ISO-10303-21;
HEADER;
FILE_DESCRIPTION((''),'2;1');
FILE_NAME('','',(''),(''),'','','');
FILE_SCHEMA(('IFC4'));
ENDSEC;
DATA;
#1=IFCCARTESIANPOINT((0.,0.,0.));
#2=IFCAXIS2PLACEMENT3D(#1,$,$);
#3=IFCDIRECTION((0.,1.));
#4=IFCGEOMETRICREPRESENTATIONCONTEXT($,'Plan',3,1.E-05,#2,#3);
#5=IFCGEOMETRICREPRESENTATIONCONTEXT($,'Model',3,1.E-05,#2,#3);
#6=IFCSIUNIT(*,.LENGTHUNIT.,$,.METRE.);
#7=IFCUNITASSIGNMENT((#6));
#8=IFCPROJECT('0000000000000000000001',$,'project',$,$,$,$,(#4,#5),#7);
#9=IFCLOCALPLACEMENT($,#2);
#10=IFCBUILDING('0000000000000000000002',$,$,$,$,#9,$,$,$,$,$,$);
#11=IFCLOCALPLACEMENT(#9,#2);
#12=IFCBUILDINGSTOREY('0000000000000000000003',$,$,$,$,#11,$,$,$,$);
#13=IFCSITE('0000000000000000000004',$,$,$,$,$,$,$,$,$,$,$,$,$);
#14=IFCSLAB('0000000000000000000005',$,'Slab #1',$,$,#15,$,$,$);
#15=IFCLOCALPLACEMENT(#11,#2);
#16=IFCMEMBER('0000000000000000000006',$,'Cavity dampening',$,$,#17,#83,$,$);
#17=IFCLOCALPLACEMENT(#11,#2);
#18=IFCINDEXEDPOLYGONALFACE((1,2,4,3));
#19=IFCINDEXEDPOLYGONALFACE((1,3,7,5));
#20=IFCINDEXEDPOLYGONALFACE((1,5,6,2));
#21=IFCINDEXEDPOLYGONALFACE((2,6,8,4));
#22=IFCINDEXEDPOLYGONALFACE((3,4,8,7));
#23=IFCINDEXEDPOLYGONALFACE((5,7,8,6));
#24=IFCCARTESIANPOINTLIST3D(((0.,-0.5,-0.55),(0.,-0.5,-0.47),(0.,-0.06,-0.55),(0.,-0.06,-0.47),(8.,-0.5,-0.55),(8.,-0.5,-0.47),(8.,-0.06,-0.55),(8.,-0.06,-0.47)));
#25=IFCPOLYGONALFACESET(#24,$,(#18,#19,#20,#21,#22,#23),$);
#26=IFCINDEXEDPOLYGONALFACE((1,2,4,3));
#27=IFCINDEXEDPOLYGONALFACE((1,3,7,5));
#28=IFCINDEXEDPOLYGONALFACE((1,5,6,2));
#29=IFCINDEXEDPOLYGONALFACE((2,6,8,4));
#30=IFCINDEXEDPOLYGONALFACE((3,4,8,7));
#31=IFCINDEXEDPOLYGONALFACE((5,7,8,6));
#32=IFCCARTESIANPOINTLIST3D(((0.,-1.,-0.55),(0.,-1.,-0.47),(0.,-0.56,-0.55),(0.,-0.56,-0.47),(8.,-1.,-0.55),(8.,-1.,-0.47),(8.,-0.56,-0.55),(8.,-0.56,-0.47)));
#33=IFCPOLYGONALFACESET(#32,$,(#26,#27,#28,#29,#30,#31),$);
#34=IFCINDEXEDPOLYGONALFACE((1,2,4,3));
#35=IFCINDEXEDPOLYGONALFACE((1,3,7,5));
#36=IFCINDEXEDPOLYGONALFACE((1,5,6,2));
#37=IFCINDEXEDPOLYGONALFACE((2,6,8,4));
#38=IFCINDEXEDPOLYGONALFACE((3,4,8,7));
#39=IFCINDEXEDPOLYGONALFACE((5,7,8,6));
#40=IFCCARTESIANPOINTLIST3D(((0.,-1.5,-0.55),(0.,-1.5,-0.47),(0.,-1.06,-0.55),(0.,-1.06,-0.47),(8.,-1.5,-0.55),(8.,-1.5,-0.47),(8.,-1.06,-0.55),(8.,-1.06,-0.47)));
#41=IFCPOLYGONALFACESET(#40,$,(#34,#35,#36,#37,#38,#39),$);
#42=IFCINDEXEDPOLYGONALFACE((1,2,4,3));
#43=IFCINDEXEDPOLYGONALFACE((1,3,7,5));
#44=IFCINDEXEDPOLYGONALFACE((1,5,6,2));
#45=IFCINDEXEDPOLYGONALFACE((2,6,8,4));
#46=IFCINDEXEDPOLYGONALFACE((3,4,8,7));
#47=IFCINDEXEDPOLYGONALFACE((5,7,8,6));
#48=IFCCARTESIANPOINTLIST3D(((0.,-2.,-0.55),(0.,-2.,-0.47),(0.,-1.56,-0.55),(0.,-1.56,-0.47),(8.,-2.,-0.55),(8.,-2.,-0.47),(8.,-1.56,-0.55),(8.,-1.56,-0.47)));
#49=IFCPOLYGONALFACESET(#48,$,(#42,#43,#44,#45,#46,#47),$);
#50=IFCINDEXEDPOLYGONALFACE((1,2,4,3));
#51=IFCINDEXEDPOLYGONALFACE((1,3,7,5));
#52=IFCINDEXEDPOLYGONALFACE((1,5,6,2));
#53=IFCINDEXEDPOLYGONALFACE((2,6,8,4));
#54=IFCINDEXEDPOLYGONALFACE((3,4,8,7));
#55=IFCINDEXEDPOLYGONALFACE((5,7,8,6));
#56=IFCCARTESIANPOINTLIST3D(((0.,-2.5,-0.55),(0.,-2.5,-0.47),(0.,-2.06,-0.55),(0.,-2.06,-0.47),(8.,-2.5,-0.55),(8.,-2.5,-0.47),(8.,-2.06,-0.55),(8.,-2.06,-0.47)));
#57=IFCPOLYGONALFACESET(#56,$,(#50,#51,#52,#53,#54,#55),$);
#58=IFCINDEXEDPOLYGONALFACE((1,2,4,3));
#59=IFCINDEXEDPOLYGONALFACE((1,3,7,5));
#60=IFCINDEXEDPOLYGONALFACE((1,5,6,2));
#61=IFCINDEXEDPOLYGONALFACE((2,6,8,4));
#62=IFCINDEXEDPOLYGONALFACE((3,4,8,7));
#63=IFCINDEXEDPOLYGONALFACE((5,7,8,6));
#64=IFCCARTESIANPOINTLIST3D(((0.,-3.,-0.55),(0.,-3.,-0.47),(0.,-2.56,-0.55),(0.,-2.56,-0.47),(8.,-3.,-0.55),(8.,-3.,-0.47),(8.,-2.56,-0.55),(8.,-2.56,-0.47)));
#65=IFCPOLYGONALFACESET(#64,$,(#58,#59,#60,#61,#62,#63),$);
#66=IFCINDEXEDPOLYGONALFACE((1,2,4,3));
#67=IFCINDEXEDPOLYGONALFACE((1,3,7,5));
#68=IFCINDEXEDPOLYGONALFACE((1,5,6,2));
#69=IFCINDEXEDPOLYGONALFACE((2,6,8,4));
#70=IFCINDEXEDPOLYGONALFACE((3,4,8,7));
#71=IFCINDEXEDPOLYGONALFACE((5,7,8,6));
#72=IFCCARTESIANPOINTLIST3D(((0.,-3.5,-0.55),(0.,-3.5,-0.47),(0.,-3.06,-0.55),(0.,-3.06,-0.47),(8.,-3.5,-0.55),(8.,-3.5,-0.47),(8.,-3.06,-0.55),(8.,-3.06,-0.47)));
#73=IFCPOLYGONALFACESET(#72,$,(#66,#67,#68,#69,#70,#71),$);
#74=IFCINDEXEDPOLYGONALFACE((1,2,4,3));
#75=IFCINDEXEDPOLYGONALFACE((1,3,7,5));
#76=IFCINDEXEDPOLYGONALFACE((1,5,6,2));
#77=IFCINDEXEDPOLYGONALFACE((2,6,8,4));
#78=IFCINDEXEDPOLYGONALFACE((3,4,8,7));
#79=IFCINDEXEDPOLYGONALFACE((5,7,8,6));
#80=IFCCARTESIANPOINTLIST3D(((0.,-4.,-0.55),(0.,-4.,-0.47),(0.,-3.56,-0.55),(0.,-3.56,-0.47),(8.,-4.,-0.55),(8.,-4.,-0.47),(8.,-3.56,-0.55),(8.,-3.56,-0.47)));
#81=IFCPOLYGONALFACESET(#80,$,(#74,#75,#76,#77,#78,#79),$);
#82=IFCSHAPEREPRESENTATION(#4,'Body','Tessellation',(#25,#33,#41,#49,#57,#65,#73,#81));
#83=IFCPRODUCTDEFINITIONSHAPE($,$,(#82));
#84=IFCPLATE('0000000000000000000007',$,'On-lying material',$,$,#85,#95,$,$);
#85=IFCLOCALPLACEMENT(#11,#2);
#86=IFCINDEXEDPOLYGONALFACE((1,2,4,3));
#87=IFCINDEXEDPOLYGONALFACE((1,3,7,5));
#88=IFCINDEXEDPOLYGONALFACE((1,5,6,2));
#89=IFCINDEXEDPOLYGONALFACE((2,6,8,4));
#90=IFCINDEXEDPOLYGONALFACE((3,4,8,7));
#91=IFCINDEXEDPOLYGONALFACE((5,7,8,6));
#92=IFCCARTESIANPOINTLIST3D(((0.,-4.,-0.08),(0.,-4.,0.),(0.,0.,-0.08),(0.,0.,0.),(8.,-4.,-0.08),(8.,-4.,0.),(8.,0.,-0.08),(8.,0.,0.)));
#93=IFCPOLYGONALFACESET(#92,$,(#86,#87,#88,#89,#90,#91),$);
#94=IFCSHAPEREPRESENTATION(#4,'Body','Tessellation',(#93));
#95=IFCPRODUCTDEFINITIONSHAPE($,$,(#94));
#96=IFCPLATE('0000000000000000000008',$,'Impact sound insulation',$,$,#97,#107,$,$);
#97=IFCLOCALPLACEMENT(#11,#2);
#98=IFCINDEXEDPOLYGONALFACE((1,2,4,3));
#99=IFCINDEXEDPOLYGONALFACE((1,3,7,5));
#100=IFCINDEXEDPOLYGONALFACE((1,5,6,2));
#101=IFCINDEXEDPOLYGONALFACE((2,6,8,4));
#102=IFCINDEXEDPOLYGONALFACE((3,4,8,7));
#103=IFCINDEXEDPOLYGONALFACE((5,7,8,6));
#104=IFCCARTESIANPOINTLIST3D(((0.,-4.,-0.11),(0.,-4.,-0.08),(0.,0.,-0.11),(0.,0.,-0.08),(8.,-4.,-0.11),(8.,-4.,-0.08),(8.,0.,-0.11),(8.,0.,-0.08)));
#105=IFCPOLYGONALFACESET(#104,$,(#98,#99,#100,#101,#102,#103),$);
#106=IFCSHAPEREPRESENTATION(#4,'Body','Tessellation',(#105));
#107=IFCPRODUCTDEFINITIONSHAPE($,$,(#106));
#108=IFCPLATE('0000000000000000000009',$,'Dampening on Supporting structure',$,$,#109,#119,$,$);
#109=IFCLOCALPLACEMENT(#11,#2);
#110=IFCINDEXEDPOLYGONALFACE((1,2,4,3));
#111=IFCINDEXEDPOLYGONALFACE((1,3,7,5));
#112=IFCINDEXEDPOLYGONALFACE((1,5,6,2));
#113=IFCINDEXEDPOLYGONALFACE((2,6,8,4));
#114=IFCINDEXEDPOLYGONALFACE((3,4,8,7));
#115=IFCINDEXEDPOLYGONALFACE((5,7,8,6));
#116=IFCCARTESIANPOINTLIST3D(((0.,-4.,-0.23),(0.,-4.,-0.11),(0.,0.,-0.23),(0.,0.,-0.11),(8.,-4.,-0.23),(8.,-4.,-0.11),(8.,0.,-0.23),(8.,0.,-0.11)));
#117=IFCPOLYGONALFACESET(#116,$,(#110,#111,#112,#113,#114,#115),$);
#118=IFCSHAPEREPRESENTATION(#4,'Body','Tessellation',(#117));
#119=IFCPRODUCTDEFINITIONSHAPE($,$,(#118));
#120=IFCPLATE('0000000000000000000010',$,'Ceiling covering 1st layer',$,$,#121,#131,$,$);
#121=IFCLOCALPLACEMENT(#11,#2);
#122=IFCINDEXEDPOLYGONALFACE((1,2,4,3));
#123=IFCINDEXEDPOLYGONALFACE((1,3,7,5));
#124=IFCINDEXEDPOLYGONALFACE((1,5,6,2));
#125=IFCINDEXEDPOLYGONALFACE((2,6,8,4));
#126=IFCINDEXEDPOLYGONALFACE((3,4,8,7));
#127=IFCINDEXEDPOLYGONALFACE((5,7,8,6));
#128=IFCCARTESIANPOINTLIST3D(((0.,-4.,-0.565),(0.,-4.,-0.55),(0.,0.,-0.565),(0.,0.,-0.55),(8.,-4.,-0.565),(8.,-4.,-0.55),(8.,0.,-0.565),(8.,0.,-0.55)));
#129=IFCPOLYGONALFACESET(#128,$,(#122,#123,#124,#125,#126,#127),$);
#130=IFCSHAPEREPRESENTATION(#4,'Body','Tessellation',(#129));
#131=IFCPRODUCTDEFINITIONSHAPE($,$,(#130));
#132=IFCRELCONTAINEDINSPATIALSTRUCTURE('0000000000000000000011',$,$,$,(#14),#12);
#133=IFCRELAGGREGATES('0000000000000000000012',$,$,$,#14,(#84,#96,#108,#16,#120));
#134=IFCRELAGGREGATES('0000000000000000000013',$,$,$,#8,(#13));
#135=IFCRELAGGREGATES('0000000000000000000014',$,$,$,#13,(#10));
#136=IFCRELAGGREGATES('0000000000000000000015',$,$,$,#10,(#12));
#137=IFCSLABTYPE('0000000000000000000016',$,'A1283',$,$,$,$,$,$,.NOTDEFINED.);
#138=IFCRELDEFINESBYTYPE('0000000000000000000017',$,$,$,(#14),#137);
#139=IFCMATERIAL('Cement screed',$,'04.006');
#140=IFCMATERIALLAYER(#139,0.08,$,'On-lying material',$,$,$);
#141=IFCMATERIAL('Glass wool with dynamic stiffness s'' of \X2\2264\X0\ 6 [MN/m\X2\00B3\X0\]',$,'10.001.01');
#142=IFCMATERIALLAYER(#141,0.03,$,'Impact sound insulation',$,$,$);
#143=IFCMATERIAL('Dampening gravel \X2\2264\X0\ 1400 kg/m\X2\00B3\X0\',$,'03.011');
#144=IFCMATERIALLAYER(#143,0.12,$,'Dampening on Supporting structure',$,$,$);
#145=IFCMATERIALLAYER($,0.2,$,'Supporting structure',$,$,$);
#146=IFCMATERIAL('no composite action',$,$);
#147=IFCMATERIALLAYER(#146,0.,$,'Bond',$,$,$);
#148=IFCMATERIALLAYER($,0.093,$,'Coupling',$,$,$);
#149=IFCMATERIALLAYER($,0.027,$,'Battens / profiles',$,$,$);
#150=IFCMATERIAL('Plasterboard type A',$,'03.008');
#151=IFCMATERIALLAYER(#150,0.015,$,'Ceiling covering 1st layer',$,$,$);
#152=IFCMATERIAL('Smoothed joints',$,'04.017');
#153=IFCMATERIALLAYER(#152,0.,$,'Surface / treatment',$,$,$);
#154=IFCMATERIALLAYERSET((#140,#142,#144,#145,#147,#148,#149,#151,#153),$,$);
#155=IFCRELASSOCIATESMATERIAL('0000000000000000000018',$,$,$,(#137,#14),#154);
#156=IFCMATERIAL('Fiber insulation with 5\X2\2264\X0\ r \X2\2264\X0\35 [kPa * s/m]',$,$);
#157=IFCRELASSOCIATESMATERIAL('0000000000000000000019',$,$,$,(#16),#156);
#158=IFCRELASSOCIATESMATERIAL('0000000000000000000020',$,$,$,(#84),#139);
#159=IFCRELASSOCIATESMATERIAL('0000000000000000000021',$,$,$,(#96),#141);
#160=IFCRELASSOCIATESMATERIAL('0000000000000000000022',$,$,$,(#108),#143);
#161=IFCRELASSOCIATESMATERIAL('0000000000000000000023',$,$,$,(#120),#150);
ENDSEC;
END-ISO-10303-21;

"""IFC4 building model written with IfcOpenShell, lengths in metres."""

from ifc_helpers import new_model, si_unit, direction, frame, frame_2d, origin, origin_with_axes, place, context, project, spatial, rectangle, extrude, material, layer, layer_set, type_object, element, aggregate, save


model = new_model("IFC4")

# Units and contexts
plan_context = context("Plan", 3, precision=1e-05, world=origin(), true_north=direction((0.0, 1.0)))
model_context = context("Model", 3, precision=1e-05, world=origin(), true_north=direction((0.0, 1.0)))
ifc_project = project(units=[si_unit("LENGTHUNIT", "METRE")], contexts=[plan_context, model_context])

# Site, building, storey
site = spatial("IfcSite", under=ifc_project)
building_placement = place(None, origin())
building = spatial("IfcBuilding", under=site, at=building_placement)
storey_placement = place(building_placement, origin())
storey = spatial("IfcBuildingStorey", under=building, at=storey_placement)

# Slab, member, plates
ifc_material_1 = material(Name="Cement screed", Category="04.006")
ifc_layer_1 = layer(ifc_material_1, 0.08, Name="On-lying material")
ifc_material_2 = material(Name="Glass wool with dynamic stiffness s' of ≤ 6 [MN/m³]", Category="10.001.01")
ifc_layer_2 = layer(ifc_material_2, 0.03, Name="Impact sound insulation")
ifc_material_3 = material(Name="Dampening gravel ≤ 1400 kg/m³", Category="03.011")
ifc_layer_3 = layer(ifc_material_3, 0.12, Name="Dampening on Supporting structure")
ifc_layer_4 = layer(None, 0.2, Name="Supporting structure")
ifc_material_4 = material(Name="no composite action")
ifc_layer_5 = layer(ifc_material_4, 0.0, Name="Bond")
ifc_layer_6 = layer(None, 0.093, Name="Coupling")
ifc_layer_7 = layer(None, 0.027, Name="Battens / profiles")
ifc_material_5 = material(Name="Plasterboard type A", Category="03.008")
ifc_layer_8 = layer(ifc_material_5, 0.015, Name="Ceiling covering 1st layer")
ifc_material_6 = material(Name="Smoothed joints", Category="04.017")
ifc_layer_9 = layer(ifc_material_6, 0.0, Name="Surface / treatment")
ifc_layer_set = layer_set([ifc_layer_1, ifc_layer_2, ifc_layer_3, ifc_layer_4, ifc_layer_5, ifc_layer_6, ifc_layer_7, ifc_layer_8, ifc_layer_9])
slab_type = type_object("IfcSlabType", Name="A1283", PredefinedType="NOTDEFINED", material=ifc_layer_set)
slab_placement = place(None, frame((0.0, 0.0, 0.0), z_axis=(0.0, 0.0, -1.0), x_axis=(1.0, 0.0, 0.0)))
slab = element("IfcSlab", 1, at=slab_placement, inside=storey, type_object=slab_type, material=ifc_layer_set, Name="Slab #1")
ifc_material_7 = material(Name="Fiber insulation with 5≤ r ≤35 [kPa * s/m]")
member_1_placement = place(slab_placement, origin())
member_1 = element("IfcMember", 2, at=member_1_placement, material=ifc_material_7, Name="Cavity dampening", context=plan_context, shape_type="SweptSolid", body=[
    extrude(rectangle(XDim=0.44, YDim=0.08, at=frame_2d((0.22, 0.04), x_axis=(1.0, 0.0))), frame((0.0, 0.06, 0.47), z_axis=(1.0, 0.0, 0.0), x_axis=(0.0, 1.0, 0.0)), (0.0, 0.0, 1.0), 8.0),
    extrude(rectangle(XDim=0.44, YDim=0.08, at=frame_2d((0.22, 0.04), x_axis=(1.0, 0.0))), frame((0.0, 0.56, 0.47), z_axis=(1.0, 0.0, 0.0), x_axis=(0.0, 1.0, 0.0)), (0.0, 0.0, 1.0), 8.0),
    extrude(rectangle(XDim=0.44, YDim=0.08, at=frame_2d((0.22, 0.04), x_axis=(1.0, 0.0))), frame((0.0, 1.06, 0.47), z_axis=(1.0, 0.0, 0.0), x_axis=(0.0, 1.0, 0.0)), (0.0, 0.0, 1.0), 8.0),
    extrude(rectangle(XDim=0.44, YDim=0.08, at=frame_2d((0.22, 0.04), x_axis=(1.0, 0.0))), frame((0.0, 1.56, 0.47), z_axis=(1.0, 0.0, 0.0), x_axis=(0.0, 1.0, 0.0)), (0.0, 0.0, 1.0), 8.0),
    extrude(rectangle(XDim=0.44, YDim=0.08, at=frame_2d((0.22, 0.04), x_axis=(1.0, 0.0))), frame((0.0, 2.06, 0.47), z_axis=(1.0, 0.0, 0.0), x_axis=(0.0, 1.0, 0.0)), (0.0, 0.0, 1.0), 8.0),
    extrude(rectangle(XDim=0.44, YDim=0.08, at=frame_2d((0.22, 0.04), x_axis=(1.0, 0.0))), frame((0.0, 2.56, 0.47), z_axis=(1.0, 0.0, 0.0), x_axis=(0.0, 1.0, 0.0)), (0.0, 0.0, 1.0), 8.0),
    extrude(rectangle(XDim=0.44, YDim=0.08, at=frame_2d((0.22, 0.04), x_axis=(1.0, 0.0))), frame((0.0, 3.06, 0.47), z_axis=(1.0, 0.0, 0.0), x_axis=(0.0, 1.0, 0.0)), (0.0, 0.0, 1.0), 8.0),
    extrude(rectangle(XDim=0.44, YDim=0.08, at=frame_2d((0.22, 0.04), x_axis=(1.0, 0.0))), frame((0.0, 3.56, 0.47), z_axis=(1.0, 0.0, 0.0), x_axis=(0.0, 1.0, 0.0)), (0.0, 0.0, 1.0), 8.0),
])
plate_1_placement = place(slab_placement, origin())
plate_1 = element("IfcPlate", 3, at=plate_1_placement, material=ifc_material_1, Name="On-lying material", context=plan_context, shape_type="SweptSolid", body=[
    extrude(rectangle(XDim=8.0, YDim=4.0, at=frame_2d((4.0, 2.0), x_axis=(1.0, 0.0))), origin_with_axes(), (0.0, 0.0, 1.0), 0.08),
])
plate_2_placement = place(slab_placement, origin())
plate_2 = element("IfcPlate", 4, at=plate_2_placement, material=ifc_material_2, Name="Impact sound insulation", context=plan_context, shape_type="SweptSolid", body=[
    extrude(rectangle(XDim=8.0, YDim=4.0, at=frame_2d((4.0, 2.0), x_axis=(1.0, 0.0))), frame((0.0, 0.0, 0.08), z_axis=(0.0, 0.0, 1.0), x_axis=(1.0, 0.0, 0.0)), (0.0, 0.0, 1.0), 0.03),
])
plate_3_placement = place(slab_placement, origin())
plate_3 = element("IfcPlate", 5, at=plate_3_placement, material=ifc_material_3, Name="Dampening on Supporting structure", context=plan_context, shape_type="SweptSolid", body=[
    extrude(rectangle(XDim=8.0, YDim=4.0, at=frame_2d((4.0, 2.0), x_axis=(1.0, 0.0))), frame((0.0, 0.0, 0.11), z_axis=(0.0, 0.0, 1.0), x_axis=(1.0, 0.0, 0.0)), (0.0, 0.0, 1.0), 0.12),
])
plate_4_placement = place(slab_placement, origin())
plate_4 = element("IfcPlate", 6, at=plate_4_placement, material=ifc_material_5, Name="Ceiling covering 1st layer", context=plan_context, shape_type="SweptSolid", body=[
    extrude(rectangle(XDim=8.0, YDim=4.0, at=frame_2d((4.0, 2.0), x_axis=(1.0, 0.0))), frame((0.0, 0.0, 0.55), z_axis=(0.0, 0.0, 1.0), x_axis=(1.0, 0.0, 0.0)), (0.0, 0.0, 1.0), 0.015),
])
aggregate(slab, [plate_1, plate_2, plate_3, member_1, plate_4])

save(model, "model.ifc")
